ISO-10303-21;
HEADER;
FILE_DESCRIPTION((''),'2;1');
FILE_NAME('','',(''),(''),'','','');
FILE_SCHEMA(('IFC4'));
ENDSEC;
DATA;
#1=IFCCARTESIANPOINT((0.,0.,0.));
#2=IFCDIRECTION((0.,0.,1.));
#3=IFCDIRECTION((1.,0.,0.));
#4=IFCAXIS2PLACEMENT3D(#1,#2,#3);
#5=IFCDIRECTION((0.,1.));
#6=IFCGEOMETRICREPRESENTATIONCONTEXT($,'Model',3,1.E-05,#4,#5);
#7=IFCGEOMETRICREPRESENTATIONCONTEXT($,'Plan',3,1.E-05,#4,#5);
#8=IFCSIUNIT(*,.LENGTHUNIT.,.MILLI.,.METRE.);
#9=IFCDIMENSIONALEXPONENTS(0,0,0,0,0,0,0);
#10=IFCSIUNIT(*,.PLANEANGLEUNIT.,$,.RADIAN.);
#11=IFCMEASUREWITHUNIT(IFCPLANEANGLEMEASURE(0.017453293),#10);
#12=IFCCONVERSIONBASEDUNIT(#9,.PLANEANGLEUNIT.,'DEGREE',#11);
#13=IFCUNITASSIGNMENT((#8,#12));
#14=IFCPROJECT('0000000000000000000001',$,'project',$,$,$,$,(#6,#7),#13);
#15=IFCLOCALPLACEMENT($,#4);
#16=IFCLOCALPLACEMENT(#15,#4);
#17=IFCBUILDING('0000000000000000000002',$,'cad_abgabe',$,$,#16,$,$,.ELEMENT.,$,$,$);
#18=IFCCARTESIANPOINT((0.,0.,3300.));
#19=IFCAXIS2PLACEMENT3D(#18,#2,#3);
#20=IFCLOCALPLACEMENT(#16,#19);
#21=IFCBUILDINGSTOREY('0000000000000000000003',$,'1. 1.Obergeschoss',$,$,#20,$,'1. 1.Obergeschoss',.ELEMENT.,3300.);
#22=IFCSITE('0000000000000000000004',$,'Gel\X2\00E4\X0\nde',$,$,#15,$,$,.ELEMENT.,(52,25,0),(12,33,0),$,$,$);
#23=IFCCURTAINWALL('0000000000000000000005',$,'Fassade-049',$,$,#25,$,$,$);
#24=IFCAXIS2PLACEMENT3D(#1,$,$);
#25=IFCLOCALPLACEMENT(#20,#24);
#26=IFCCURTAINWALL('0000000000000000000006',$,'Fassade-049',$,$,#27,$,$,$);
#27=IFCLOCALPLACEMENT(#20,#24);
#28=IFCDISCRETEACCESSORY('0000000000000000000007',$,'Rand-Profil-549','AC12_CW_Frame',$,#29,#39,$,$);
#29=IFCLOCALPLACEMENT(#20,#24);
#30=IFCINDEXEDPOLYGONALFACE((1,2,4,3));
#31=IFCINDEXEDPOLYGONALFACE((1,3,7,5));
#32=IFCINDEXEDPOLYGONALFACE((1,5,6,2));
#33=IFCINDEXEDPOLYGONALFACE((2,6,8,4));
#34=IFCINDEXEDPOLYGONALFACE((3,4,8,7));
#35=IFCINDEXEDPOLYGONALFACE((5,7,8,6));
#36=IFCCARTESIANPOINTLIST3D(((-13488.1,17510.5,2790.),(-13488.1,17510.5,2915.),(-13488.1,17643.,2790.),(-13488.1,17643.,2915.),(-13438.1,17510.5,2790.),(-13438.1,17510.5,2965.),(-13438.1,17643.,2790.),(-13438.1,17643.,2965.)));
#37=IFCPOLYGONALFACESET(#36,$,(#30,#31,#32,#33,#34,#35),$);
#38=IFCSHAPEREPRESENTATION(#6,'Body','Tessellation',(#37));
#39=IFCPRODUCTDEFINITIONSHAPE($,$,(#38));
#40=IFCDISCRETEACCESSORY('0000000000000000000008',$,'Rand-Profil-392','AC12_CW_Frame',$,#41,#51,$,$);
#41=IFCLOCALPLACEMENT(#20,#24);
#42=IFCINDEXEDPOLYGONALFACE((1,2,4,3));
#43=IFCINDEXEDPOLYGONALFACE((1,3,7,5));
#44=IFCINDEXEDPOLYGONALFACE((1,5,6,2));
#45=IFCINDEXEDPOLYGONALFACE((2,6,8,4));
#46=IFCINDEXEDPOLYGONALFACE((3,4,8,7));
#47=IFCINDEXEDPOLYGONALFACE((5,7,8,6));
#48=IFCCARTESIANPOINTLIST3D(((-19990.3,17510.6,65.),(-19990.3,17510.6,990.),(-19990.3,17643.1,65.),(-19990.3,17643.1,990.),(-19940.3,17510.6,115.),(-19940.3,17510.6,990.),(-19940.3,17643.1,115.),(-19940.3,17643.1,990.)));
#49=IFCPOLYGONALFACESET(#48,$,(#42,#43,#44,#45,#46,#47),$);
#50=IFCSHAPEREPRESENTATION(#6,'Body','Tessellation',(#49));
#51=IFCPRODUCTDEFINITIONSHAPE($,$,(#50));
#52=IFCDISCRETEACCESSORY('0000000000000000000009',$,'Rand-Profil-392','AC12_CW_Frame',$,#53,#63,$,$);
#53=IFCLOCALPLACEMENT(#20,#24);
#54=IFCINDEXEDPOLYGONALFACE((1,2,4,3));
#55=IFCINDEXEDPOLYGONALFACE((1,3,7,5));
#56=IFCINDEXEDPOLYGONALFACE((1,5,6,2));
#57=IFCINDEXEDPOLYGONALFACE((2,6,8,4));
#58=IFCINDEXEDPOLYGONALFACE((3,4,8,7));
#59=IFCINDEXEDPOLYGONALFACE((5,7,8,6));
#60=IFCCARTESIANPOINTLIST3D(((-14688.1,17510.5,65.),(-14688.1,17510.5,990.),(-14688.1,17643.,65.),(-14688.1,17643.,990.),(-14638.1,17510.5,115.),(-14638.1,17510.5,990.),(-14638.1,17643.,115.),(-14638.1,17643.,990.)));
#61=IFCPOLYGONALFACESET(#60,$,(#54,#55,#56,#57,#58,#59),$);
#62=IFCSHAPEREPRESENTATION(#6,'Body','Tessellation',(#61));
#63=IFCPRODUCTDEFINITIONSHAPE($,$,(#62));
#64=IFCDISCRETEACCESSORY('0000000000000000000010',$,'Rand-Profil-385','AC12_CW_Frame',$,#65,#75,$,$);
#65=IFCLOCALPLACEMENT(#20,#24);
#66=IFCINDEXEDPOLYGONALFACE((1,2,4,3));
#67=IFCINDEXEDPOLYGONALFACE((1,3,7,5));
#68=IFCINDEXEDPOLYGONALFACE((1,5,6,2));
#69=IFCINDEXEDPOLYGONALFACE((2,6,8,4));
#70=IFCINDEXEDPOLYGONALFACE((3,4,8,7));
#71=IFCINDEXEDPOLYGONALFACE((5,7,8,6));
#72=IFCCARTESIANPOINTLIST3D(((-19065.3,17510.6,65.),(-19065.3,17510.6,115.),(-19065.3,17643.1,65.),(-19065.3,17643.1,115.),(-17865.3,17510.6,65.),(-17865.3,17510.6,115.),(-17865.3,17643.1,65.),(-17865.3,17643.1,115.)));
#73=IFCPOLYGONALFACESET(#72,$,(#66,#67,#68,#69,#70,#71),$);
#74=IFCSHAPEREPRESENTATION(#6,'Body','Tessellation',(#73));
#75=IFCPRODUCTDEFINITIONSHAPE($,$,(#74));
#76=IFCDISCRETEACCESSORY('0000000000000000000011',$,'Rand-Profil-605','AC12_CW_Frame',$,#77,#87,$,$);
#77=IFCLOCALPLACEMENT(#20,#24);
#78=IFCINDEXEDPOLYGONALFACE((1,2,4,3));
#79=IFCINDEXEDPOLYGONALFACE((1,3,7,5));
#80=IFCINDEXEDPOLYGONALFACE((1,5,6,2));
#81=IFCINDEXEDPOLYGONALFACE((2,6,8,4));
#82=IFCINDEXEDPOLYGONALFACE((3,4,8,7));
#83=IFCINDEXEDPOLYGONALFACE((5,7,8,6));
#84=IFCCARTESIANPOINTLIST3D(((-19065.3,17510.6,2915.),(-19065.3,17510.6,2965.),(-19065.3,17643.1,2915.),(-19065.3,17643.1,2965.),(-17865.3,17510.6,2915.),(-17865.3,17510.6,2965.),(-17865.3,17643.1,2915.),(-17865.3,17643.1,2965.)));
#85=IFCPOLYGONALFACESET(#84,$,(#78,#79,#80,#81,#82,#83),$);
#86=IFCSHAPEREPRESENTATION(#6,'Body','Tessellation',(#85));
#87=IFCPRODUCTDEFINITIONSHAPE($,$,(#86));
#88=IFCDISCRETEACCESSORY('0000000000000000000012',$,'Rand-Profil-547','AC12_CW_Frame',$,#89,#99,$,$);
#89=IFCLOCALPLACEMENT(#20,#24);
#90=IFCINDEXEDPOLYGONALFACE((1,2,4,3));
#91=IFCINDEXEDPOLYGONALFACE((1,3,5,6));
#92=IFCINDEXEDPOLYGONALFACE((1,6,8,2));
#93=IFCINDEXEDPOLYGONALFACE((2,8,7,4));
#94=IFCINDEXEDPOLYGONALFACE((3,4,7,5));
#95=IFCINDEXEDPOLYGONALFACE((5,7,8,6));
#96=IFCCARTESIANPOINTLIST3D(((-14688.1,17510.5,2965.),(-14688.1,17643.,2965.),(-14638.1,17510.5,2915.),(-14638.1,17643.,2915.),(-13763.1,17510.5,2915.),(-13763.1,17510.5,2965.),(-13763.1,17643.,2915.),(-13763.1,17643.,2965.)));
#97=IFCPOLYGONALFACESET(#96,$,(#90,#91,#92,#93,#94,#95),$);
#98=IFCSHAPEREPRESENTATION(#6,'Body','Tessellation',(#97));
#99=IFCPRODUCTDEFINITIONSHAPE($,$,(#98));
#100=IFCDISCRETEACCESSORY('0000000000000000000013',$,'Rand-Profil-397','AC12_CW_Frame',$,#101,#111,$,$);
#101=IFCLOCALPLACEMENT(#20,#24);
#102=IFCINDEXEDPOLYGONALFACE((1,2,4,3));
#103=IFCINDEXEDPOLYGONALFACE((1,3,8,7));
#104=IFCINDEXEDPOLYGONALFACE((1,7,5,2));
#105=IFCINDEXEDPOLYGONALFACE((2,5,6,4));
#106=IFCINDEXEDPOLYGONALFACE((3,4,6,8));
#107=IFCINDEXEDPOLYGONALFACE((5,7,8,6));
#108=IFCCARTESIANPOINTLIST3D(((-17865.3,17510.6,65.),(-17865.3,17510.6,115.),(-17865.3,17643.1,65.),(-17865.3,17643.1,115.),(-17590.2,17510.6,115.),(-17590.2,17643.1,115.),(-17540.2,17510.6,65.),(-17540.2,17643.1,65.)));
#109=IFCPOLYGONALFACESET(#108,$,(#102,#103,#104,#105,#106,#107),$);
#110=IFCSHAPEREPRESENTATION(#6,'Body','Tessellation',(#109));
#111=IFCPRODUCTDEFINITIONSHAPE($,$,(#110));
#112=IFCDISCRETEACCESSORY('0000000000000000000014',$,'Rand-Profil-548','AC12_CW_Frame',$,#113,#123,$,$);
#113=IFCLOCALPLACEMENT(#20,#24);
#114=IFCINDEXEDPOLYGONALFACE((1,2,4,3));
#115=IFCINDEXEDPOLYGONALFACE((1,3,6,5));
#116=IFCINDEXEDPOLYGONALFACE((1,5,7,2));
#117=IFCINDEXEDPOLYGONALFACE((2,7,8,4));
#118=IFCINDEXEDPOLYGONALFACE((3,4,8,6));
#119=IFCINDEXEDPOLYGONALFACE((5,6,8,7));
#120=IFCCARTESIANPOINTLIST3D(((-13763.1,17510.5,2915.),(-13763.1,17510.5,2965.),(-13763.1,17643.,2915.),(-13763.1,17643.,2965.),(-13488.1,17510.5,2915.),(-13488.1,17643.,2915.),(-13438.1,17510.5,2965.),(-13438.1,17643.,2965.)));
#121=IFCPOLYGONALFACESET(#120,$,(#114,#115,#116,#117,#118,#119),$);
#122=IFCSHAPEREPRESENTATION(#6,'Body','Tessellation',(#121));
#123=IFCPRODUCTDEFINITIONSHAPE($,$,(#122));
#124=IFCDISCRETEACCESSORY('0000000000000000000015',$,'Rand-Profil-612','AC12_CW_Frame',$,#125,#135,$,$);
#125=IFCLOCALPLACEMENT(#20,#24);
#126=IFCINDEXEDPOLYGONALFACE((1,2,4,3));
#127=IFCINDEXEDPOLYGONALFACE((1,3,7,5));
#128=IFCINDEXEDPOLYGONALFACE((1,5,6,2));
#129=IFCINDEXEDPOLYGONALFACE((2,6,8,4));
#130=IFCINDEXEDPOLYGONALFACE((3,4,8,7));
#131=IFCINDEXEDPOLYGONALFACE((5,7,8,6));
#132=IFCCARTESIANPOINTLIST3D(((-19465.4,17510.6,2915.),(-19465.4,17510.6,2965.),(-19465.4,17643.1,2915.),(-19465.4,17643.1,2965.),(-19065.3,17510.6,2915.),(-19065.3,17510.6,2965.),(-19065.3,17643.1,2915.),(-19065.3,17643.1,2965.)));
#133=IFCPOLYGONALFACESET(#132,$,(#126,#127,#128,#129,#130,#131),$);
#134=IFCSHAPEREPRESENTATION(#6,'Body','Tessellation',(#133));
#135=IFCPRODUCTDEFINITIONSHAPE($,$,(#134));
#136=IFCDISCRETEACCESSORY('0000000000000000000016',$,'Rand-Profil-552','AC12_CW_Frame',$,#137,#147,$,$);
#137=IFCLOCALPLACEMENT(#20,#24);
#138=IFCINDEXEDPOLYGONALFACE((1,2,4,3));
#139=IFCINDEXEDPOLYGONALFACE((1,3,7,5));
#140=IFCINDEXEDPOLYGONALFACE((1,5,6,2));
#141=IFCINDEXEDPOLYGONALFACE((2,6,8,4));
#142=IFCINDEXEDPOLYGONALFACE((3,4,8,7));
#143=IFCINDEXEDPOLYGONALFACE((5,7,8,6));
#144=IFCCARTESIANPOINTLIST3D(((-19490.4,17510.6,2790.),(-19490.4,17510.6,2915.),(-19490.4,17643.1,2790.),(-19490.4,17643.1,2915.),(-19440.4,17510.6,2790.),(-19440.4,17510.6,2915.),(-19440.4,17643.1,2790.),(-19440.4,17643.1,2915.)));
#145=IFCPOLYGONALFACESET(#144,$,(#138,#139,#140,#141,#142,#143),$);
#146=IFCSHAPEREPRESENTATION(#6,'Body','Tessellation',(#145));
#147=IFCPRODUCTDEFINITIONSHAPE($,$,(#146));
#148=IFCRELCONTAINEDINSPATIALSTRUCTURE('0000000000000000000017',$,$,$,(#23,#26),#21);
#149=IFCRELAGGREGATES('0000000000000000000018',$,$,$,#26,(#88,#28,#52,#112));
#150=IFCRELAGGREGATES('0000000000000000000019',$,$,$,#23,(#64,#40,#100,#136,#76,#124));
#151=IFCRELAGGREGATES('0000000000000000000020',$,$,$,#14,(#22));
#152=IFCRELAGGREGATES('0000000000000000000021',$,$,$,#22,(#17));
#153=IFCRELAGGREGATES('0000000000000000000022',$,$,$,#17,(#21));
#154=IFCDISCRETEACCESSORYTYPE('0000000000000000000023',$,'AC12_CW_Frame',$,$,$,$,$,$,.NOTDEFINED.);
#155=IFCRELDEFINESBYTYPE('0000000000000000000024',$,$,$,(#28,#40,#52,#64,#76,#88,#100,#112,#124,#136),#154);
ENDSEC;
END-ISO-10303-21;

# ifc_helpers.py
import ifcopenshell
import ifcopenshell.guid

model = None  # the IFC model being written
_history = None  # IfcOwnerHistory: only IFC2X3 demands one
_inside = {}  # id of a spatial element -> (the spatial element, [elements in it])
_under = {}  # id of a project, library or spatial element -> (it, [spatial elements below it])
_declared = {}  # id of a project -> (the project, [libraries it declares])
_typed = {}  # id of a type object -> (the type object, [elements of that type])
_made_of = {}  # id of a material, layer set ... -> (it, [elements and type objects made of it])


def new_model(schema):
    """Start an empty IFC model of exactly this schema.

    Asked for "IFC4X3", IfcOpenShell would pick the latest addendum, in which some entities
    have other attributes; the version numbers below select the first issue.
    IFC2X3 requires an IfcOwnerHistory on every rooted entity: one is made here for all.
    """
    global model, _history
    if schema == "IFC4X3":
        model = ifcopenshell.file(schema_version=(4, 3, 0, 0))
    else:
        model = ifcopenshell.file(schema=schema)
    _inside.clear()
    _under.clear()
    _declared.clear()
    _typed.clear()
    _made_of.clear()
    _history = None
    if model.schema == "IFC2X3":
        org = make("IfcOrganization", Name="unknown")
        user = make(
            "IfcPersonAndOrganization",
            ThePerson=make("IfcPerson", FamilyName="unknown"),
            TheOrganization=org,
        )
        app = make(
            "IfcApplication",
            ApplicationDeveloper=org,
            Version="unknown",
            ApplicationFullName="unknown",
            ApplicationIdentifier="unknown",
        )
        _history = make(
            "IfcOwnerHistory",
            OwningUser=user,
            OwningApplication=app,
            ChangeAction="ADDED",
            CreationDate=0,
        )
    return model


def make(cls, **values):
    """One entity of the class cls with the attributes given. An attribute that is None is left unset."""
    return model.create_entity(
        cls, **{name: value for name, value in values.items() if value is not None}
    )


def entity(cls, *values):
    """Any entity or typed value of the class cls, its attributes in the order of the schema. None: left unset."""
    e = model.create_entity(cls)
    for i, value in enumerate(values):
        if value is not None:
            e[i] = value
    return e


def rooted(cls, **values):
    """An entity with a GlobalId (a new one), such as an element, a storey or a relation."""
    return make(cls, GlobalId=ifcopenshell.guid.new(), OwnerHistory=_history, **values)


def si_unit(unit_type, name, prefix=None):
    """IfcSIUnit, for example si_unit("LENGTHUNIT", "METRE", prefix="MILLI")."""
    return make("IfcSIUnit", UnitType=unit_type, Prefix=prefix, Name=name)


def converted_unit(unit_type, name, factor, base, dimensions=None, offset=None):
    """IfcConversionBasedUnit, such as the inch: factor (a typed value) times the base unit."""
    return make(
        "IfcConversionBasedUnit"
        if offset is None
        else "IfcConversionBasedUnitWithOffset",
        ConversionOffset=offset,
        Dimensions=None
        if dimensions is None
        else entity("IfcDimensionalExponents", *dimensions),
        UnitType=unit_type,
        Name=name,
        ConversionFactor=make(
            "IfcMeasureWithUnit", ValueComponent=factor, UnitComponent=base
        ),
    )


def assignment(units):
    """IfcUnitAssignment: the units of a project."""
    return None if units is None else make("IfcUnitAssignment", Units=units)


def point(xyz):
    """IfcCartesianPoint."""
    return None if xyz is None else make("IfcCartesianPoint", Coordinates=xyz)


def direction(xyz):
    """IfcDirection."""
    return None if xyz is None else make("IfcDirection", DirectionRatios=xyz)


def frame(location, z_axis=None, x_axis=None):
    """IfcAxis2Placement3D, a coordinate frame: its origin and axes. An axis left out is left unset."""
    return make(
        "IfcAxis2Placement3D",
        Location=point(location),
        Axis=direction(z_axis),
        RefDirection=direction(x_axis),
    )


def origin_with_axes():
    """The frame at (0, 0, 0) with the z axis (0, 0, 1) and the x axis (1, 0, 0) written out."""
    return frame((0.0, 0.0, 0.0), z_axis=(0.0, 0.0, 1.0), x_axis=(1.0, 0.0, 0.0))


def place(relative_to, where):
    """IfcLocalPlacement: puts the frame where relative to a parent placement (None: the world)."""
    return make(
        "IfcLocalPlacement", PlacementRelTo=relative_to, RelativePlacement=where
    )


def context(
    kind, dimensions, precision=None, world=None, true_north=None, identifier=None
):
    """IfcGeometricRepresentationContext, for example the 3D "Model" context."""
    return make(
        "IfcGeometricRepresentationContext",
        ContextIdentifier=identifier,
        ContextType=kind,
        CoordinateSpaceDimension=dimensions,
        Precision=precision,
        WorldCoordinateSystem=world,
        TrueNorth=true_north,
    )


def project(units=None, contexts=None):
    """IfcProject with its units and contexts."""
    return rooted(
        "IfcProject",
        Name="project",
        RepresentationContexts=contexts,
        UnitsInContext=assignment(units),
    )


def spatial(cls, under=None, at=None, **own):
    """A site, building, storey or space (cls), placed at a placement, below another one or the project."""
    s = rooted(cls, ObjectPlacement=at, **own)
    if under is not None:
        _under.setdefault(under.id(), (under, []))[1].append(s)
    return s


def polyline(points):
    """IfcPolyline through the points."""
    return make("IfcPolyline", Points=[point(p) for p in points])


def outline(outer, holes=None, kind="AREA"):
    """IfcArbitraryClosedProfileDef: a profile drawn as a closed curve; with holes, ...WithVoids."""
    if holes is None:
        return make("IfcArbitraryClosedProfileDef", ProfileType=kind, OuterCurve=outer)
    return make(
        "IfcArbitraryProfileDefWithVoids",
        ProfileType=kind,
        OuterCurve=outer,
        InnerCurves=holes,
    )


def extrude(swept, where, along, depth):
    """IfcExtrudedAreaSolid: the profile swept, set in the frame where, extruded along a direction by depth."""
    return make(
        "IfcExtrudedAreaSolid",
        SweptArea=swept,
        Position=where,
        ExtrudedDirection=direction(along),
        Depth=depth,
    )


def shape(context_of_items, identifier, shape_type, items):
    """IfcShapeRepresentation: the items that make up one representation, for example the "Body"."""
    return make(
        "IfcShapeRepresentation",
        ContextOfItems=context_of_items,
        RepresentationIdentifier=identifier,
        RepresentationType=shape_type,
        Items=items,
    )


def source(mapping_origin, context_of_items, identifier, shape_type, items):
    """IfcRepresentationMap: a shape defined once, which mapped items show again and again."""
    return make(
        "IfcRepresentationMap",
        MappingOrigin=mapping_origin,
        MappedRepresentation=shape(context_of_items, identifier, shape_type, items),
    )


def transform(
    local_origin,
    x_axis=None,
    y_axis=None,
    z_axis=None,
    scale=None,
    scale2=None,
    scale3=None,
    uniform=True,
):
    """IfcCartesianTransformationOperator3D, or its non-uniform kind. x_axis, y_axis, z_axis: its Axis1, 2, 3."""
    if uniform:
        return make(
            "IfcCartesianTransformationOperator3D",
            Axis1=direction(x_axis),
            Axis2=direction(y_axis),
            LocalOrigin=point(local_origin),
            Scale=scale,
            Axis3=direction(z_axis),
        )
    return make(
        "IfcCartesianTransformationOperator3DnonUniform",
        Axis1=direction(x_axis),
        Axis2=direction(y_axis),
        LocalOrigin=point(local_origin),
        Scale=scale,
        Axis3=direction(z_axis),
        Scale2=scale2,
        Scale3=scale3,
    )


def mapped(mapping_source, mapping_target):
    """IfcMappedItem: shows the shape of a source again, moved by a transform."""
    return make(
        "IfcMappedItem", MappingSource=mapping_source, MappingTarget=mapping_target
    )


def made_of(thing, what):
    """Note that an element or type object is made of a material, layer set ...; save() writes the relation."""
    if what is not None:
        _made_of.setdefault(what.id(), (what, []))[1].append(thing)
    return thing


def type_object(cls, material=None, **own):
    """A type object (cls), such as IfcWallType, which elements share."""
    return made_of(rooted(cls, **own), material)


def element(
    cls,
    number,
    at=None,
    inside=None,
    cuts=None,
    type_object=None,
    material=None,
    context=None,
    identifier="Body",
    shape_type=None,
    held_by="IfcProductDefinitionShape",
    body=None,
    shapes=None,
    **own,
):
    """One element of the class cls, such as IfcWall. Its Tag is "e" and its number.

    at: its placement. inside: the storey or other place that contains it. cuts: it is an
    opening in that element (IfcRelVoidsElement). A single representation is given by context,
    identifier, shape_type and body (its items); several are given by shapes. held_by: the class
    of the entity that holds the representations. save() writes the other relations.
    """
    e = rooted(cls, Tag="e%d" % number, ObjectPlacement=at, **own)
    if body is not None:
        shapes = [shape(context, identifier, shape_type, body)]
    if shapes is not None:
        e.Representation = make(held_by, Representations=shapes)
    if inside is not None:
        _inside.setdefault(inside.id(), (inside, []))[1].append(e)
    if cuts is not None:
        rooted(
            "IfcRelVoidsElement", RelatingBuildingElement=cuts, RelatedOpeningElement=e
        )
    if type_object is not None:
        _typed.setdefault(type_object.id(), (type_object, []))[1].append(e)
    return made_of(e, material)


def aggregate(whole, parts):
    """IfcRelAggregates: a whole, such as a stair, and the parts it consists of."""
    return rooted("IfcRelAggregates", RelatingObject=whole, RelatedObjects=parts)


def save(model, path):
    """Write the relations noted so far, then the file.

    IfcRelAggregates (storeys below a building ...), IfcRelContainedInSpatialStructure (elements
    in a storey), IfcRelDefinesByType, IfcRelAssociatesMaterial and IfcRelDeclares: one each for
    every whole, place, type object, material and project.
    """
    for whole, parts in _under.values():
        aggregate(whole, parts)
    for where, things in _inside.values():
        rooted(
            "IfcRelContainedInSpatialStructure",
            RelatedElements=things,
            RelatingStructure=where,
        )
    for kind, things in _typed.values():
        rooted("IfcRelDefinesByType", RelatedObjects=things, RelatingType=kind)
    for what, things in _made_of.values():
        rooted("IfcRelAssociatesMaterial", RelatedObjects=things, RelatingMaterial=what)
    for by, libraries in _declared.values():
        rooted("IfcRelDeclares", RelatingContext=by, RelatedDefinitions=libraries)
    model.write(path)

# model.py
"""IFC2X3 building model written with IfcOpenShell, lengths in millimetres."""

from ifc_helpers import new_model, entity, si_unit, converted_unit, direction, frame, origin_with_axes, place, context, project, spatial, polyline, outline, extrude, source, transform, mapped, type_object, element, aggregate, save


model = new_model("IFC2X3")

# Units and contexts
model_context = context("Model", 3, precision=1e-05, world=origin_with_axes(), true_north=direction((0.0, 1.0)))
plan_context = context("Plan", 3, precision=1e-05, world=origin_with_axes(), true_north=direction((0.0, 1.0)))
ifc_project = project(units=[si_unit("LENGTHUNIT", "METRE", prefix="MILLI"), converted_unit("PLANEANGLEUNIT", "DEGREE", entity("IfcPlaneAngleMeasure", 0.017453293), si_unit("PLANEANGLEUNIT", "RADIAN"), dimensions=[0, 0, 0, 0, 0, 0, 0])], contexts=[model_context, plan_context])

# Site, building, storey
site_placement = place(None, origin_with_axes())
site = spatial("IfcSite", under=ifc_project, at=site_placement, Name="Gelände", CompositionType="ELEMENT", RefLatitude=(52, 25, 0), RefLongitude=(12, 33, 0))
building_placement = place(site_placement, origin_with_axes())
building = spatial("IfcBuilding", under=site, at=building_placement, Name="cad_abgabe", CompositionType="ELEMENT")
storey_placement = place(building_placement, frame((0.0, 0.0, 3300.0), z_axis=(0.0, 0.0, 1.0), x_axis=(1.0, 0.0, 0.0)))
storey = spatial("IfcBuildingStorey", under=building, at=storey_placement, Name="1. 1.Obergeschoss", LongName="1. 1.Obergeschoss", CompositionType="ELEMENT", Elevation=3300.0)

# Curtain walls
curtain_wall_1_placement = place(storey_placement, frame((-19965.3, 17588.1, 90.0), z_axis=(0.0, 0.0, 1.0), x_axis=(1.0, 0.0, 0.0)))
curtain_wall_1 = element("IfcCurtainWall", 1, at=curtain_wall_1_placement, inside=storey, Name="Fassade-049")
discrete_accessory_type = type_object("IfcDiscreteAccessoryType", Name="AC12_CW_Frame")
curtain_wall_2_placement = place(storey_placement, frame((-14663.1, 17588.0, 90.0), z_axis=(0.0, 0.0, 1.0), x_axis=(1.0, 0.0, 0.0)))
curtain_wall_2 = element("IfcCurtainWall", 2, at=curtain_wall_2_placement, inside=storey, Name="Fassade-049")

# Discrete accessories
shared_shape_1 = source(origin_with_axes(), model_context, "Body", "SweptSolid", [
    extrude(outline(polyline([(0.0, 0.0), (175.0, 0.0), (125.0, -50.0), (0.0, -50.0), (0.0, 0.0)])), origin_with_axes(), (0.0, 0.0, 1.0), 132.5),
])
discrete_accessory_1_placement = place(storey_placement, frame((-13438.1, 17510.5, 2790.0), z_axis=(0.0, 1.0, 0.0), x_axis=(0.0, 0.0, 1.0)))
discrete_accessory_1 = element("IfcDiscreteAccessory", 3, at=discrete_accessory_1_placement, type_object=discrete_accessory_type, Name="Rand-Profil-549", Description="AC12_CW_Frame", context=model_context, shape_type="MappedRepresentation", body=[
    mapped(shared_shape_1, transform((0.0, 0.0, 0.0), scale=1.0)),
])
shared_shape_2 = source(origin_with_axes(), model_context, "Body", "SweptSolid", [
    extrude(outline(polyline([(0.0, 0.0), (875.0, 0.0), (875.0, -50.0), (-50.0, -50.0), (0.0, 0.0)])), origin_with_axes(), (0.0, 0.0, 1.0), 132.5),
])
discrete_accessory_2_placement = place(storey_placement, frame((-19940.3, 17510.6, 115.0), z_axis=(0.0, 1.0, 0.0), x_axis=(0.0, 0.0, 1.0)))
discrete_accessory_2 = element("IfcDiscreteAccessory", 4, at=discrete_accessory_2_placement, type_object=discrete_accessory_type, Name="Rand-Profil-392", Description="AC12_CW_Frame", context=model_context, shape_type="MappedRepresentation", body=[
    mapped(shared_shape_2, transform((0.0, 0.0, 0.0), scale=1.0)),
])
discrete_accessory_3_placement = place(storey_placement, frame((-14638.1, 17510.5, 115.0), z_axis=(0.0, 1.0, 0.0), x_axis=(0.0, 0.0, 1.0)))
discrete_accessory_3 = element("IfcDiscreteAccessory", 5, at=discrete_accessory_3_placement, type_object=discrete_accessory_type, Name="Rand-Profil-392", Description="AC12_CW_Frame", context=model_context, shape_type="MappedRepresentation", body=[
    mapped(shared_shape_2, transform((0.0, 0.0, 0.0), scale=1.0)),
])
shared_shape_3 = source(origin_with_axes(), model_context, "Body", "SweptSolid", [
    extrude(outline(polyline([(0.0, 0.0), (1200.0, 0.0), (1200.0, -132.5), (0.0, -132.5), (0.0, 0.0)])), origin_with_axes(), (0.0, 0.0, 1.0), 50.0),
])
discrete_accessory_4_placement = place(storey_placement, frame((-19065.3, 17510.6, 115.0), z_axis=(0.0, 0.0, -1.0), x_axis=(1.0, 0.0, 0.0)))
discrete_accessory_4 = element("IfcDiscreteAccessory", 6, at=discrete_accessory_4_placement, type_object=discrete_accessory_type, Name="Rand-Profil-385", Description="AC12_CW_Frame", context=model_context, shape_type="MappedRepresentation", body=[
    mapped(shared_shape_3, transform((0.0, 0.0, 0.0), scale=1.0)),
])
discrete_accessory_5_placement = place(storey_placement, frame((-17865.3, 17510.6, 2915.0), z_axis=(0.0, 0.0, 1.0), x_axis=(-1.0, 0.0, 0.0)))
discrete_accessory_5 = element("IfcDiscreteAccessory", 7, at=discrete_accessory_5_placement, type_object=discrete_accessory_type, Name="Rand-Profil-605", Description="AC12_CW_Frame", context=model_context, shape_type="MappedRepresentation", body=[
    mapped(shared_shape_3, transform((0.0, 0.0, 0.0), scale=1.0)),
])
shared_shape_4 = source(origin_with_axes(), model_context, "Body", "SweptSolid", [
    extrude(outline(polyline([(0.0, 0.0), (925.0, 0.0), (875.0, -50.0), (0.0, -50.0), (0.0, 0.0)])), origin_with_axes(), (0.0, 0.0, 1.0), 132.5),
])
discrete_accessory_6_placement = place(storey_placement, frame((-13763.1, 17510.5, 2965.0), z_axis=(0.0, 1.0, 0.0), x_axis=(-1.0, 0.0, 0.0)))
discrete_accessory_6 = element("IfcDiscreteAccessory", 8, at=discrete_accessory_6_placement, type_object=discrete_accessory_type, Name="Rand-Profil-547", Description="AC12_CW_Frame", context=model_context, shape_type="MappedRepresentation", body=[
    mapped(shared_shape_4, transform((0.0, 0.0, 0.0), scale=1.0)),
])
shared_shape_5 = source(origin_with_axes(), model_context, "Body", "SweptSolid", [
    extrude(outline(polyline([(0.0, 0.0), (325.1, 0.0), (275.1, -50.0), (0.0, -50.0), (0.0, 0.0)])), origin_with_axes(), (0.0, 0.0, 1.0), 132.5),
])
discrete_accessory_7_placement = place(storey_placement, frame((-17865.3, 17510.6, 65.0), z_axis=(0.0, 1.0, 0.0), x_axis=(1.0, 0.0, 0.0)))
discrete_accessory_7 = element("IfcDiscreteAccessory", 9, at=discrete_accessory_7_placement, type_object=discrete_accessory_type, Name="Rand-Profil-397", Description="AC12_CW_Frame", context=model_context, shape_type="MappedRepresentation", body=[
    mapped(shared_shape_5, transform((0.0, 0.0, 0.0), scale=1.0)),
])
shared_shape_6 = source(origin_with_axes(), model_context, "Body", "SweptSolid", [
    extrude(outline(polyline([(0.0, 0.0), (325.0, 0.0), (325.0, -50.0), (50.0, -50.0), (0.0, 0.0)])), origin_with_axes(), (0.0, 0.0, 1.0), 132.5),
])
discrete_accessory_8_placement = place(storey_placement, frame((-13438.1, 17510.5, 2965.0), z_axis=(0.0, 1.0, 0.0), x_axis=(-1.0, 0.0, 0.0)))
discrete_accessory_8 = element("IfcDiscreteAccessory", 10, at=discrete_accessory_8_placement, type_object=discrete_accessory_type, Name="Rand-Profil-548", Description="AC12_CW_Frame", context=model_context, shape_type="MappedRepresentation", body=[
    mapped(shared_shape_6, transform((0.0, 0.0, 0.0), scale=1.0)),
])
aggregate(curtain_wall_2, [discrete_accessory_6, discrete_accessory_1, discrete_accessory_3, discrete_accessory_8])
shared_shape_7 = source(origin_with_axes(), model_context, "Body", "SweptSolid", [
    extrude(outline(polyline([(0.0, 0.0), (400.1, 0.0), (400.1, -132.5), (0.0, -132.5), (0.0, 0.0)])), origin_with_axes(), (0.0, 0.0, 1.0), 50.0),
])
discrete_accessory_9_placement = place(storey_placement, frame((-19065.3, 17510.6, 2915.0), z_axis=(0.0, 0.0, 1.0), x_axis=(-1.0, 0.0, 0.0)))
discrete_accessory_9 = element("IfcDiscreteAccessory", 11, at=discrete_accessory_9_placement, type_object=discrete_accessory_type, Name="Rand-Profil-612", Description="AC12_CW_Frame", context=model_context, shape_type="MappedRepresentation", body=[
    mapped(shared_shape_7, transform((0.0, 0.0, 0.0), scale=1.0)),
])
shared_shape_8 = source(origin_with_axes(), model_context, "Body", "SweptSolid", [
    extrude(outline(polyline([(0.0, 0.0), (125.0, 0.0), (125.0, -132.5), (0.0, -132.5), (0.0, 0.0)])), origin_with_axes(), (0.0, 0.0, 1.0), 50.0),
])
discrete_accessory_10_placement = place(storey_placement, frame((-19490.4, 17510.6, 2790.0), z_axis=(1.0, 0.0, 0.0), x_axis=(0.0, 0.0, 1.0)))
discrete_accessory_10 = element("IfcDiscreteAccessory", 12, at=discrete_accessory_10_placement, type_object=discrete_accessory_type, Name="Rand-Profil-552", Description="AC12_CW_Frame", context=model_context, shape_type="MappedRepresentation", body=[
    mapped(shared_shape_8, transform((0.0, 0.0, 0.0), scale=1.0)),
])
aggregate(curtain_wall_1, [discrete_accessory_4, discrete_accessory_2, discrete_accessory_7, discrete_accessory_10, discrete_accessory_5, discrete_accessory_9])

save(model, "model.ifc")
